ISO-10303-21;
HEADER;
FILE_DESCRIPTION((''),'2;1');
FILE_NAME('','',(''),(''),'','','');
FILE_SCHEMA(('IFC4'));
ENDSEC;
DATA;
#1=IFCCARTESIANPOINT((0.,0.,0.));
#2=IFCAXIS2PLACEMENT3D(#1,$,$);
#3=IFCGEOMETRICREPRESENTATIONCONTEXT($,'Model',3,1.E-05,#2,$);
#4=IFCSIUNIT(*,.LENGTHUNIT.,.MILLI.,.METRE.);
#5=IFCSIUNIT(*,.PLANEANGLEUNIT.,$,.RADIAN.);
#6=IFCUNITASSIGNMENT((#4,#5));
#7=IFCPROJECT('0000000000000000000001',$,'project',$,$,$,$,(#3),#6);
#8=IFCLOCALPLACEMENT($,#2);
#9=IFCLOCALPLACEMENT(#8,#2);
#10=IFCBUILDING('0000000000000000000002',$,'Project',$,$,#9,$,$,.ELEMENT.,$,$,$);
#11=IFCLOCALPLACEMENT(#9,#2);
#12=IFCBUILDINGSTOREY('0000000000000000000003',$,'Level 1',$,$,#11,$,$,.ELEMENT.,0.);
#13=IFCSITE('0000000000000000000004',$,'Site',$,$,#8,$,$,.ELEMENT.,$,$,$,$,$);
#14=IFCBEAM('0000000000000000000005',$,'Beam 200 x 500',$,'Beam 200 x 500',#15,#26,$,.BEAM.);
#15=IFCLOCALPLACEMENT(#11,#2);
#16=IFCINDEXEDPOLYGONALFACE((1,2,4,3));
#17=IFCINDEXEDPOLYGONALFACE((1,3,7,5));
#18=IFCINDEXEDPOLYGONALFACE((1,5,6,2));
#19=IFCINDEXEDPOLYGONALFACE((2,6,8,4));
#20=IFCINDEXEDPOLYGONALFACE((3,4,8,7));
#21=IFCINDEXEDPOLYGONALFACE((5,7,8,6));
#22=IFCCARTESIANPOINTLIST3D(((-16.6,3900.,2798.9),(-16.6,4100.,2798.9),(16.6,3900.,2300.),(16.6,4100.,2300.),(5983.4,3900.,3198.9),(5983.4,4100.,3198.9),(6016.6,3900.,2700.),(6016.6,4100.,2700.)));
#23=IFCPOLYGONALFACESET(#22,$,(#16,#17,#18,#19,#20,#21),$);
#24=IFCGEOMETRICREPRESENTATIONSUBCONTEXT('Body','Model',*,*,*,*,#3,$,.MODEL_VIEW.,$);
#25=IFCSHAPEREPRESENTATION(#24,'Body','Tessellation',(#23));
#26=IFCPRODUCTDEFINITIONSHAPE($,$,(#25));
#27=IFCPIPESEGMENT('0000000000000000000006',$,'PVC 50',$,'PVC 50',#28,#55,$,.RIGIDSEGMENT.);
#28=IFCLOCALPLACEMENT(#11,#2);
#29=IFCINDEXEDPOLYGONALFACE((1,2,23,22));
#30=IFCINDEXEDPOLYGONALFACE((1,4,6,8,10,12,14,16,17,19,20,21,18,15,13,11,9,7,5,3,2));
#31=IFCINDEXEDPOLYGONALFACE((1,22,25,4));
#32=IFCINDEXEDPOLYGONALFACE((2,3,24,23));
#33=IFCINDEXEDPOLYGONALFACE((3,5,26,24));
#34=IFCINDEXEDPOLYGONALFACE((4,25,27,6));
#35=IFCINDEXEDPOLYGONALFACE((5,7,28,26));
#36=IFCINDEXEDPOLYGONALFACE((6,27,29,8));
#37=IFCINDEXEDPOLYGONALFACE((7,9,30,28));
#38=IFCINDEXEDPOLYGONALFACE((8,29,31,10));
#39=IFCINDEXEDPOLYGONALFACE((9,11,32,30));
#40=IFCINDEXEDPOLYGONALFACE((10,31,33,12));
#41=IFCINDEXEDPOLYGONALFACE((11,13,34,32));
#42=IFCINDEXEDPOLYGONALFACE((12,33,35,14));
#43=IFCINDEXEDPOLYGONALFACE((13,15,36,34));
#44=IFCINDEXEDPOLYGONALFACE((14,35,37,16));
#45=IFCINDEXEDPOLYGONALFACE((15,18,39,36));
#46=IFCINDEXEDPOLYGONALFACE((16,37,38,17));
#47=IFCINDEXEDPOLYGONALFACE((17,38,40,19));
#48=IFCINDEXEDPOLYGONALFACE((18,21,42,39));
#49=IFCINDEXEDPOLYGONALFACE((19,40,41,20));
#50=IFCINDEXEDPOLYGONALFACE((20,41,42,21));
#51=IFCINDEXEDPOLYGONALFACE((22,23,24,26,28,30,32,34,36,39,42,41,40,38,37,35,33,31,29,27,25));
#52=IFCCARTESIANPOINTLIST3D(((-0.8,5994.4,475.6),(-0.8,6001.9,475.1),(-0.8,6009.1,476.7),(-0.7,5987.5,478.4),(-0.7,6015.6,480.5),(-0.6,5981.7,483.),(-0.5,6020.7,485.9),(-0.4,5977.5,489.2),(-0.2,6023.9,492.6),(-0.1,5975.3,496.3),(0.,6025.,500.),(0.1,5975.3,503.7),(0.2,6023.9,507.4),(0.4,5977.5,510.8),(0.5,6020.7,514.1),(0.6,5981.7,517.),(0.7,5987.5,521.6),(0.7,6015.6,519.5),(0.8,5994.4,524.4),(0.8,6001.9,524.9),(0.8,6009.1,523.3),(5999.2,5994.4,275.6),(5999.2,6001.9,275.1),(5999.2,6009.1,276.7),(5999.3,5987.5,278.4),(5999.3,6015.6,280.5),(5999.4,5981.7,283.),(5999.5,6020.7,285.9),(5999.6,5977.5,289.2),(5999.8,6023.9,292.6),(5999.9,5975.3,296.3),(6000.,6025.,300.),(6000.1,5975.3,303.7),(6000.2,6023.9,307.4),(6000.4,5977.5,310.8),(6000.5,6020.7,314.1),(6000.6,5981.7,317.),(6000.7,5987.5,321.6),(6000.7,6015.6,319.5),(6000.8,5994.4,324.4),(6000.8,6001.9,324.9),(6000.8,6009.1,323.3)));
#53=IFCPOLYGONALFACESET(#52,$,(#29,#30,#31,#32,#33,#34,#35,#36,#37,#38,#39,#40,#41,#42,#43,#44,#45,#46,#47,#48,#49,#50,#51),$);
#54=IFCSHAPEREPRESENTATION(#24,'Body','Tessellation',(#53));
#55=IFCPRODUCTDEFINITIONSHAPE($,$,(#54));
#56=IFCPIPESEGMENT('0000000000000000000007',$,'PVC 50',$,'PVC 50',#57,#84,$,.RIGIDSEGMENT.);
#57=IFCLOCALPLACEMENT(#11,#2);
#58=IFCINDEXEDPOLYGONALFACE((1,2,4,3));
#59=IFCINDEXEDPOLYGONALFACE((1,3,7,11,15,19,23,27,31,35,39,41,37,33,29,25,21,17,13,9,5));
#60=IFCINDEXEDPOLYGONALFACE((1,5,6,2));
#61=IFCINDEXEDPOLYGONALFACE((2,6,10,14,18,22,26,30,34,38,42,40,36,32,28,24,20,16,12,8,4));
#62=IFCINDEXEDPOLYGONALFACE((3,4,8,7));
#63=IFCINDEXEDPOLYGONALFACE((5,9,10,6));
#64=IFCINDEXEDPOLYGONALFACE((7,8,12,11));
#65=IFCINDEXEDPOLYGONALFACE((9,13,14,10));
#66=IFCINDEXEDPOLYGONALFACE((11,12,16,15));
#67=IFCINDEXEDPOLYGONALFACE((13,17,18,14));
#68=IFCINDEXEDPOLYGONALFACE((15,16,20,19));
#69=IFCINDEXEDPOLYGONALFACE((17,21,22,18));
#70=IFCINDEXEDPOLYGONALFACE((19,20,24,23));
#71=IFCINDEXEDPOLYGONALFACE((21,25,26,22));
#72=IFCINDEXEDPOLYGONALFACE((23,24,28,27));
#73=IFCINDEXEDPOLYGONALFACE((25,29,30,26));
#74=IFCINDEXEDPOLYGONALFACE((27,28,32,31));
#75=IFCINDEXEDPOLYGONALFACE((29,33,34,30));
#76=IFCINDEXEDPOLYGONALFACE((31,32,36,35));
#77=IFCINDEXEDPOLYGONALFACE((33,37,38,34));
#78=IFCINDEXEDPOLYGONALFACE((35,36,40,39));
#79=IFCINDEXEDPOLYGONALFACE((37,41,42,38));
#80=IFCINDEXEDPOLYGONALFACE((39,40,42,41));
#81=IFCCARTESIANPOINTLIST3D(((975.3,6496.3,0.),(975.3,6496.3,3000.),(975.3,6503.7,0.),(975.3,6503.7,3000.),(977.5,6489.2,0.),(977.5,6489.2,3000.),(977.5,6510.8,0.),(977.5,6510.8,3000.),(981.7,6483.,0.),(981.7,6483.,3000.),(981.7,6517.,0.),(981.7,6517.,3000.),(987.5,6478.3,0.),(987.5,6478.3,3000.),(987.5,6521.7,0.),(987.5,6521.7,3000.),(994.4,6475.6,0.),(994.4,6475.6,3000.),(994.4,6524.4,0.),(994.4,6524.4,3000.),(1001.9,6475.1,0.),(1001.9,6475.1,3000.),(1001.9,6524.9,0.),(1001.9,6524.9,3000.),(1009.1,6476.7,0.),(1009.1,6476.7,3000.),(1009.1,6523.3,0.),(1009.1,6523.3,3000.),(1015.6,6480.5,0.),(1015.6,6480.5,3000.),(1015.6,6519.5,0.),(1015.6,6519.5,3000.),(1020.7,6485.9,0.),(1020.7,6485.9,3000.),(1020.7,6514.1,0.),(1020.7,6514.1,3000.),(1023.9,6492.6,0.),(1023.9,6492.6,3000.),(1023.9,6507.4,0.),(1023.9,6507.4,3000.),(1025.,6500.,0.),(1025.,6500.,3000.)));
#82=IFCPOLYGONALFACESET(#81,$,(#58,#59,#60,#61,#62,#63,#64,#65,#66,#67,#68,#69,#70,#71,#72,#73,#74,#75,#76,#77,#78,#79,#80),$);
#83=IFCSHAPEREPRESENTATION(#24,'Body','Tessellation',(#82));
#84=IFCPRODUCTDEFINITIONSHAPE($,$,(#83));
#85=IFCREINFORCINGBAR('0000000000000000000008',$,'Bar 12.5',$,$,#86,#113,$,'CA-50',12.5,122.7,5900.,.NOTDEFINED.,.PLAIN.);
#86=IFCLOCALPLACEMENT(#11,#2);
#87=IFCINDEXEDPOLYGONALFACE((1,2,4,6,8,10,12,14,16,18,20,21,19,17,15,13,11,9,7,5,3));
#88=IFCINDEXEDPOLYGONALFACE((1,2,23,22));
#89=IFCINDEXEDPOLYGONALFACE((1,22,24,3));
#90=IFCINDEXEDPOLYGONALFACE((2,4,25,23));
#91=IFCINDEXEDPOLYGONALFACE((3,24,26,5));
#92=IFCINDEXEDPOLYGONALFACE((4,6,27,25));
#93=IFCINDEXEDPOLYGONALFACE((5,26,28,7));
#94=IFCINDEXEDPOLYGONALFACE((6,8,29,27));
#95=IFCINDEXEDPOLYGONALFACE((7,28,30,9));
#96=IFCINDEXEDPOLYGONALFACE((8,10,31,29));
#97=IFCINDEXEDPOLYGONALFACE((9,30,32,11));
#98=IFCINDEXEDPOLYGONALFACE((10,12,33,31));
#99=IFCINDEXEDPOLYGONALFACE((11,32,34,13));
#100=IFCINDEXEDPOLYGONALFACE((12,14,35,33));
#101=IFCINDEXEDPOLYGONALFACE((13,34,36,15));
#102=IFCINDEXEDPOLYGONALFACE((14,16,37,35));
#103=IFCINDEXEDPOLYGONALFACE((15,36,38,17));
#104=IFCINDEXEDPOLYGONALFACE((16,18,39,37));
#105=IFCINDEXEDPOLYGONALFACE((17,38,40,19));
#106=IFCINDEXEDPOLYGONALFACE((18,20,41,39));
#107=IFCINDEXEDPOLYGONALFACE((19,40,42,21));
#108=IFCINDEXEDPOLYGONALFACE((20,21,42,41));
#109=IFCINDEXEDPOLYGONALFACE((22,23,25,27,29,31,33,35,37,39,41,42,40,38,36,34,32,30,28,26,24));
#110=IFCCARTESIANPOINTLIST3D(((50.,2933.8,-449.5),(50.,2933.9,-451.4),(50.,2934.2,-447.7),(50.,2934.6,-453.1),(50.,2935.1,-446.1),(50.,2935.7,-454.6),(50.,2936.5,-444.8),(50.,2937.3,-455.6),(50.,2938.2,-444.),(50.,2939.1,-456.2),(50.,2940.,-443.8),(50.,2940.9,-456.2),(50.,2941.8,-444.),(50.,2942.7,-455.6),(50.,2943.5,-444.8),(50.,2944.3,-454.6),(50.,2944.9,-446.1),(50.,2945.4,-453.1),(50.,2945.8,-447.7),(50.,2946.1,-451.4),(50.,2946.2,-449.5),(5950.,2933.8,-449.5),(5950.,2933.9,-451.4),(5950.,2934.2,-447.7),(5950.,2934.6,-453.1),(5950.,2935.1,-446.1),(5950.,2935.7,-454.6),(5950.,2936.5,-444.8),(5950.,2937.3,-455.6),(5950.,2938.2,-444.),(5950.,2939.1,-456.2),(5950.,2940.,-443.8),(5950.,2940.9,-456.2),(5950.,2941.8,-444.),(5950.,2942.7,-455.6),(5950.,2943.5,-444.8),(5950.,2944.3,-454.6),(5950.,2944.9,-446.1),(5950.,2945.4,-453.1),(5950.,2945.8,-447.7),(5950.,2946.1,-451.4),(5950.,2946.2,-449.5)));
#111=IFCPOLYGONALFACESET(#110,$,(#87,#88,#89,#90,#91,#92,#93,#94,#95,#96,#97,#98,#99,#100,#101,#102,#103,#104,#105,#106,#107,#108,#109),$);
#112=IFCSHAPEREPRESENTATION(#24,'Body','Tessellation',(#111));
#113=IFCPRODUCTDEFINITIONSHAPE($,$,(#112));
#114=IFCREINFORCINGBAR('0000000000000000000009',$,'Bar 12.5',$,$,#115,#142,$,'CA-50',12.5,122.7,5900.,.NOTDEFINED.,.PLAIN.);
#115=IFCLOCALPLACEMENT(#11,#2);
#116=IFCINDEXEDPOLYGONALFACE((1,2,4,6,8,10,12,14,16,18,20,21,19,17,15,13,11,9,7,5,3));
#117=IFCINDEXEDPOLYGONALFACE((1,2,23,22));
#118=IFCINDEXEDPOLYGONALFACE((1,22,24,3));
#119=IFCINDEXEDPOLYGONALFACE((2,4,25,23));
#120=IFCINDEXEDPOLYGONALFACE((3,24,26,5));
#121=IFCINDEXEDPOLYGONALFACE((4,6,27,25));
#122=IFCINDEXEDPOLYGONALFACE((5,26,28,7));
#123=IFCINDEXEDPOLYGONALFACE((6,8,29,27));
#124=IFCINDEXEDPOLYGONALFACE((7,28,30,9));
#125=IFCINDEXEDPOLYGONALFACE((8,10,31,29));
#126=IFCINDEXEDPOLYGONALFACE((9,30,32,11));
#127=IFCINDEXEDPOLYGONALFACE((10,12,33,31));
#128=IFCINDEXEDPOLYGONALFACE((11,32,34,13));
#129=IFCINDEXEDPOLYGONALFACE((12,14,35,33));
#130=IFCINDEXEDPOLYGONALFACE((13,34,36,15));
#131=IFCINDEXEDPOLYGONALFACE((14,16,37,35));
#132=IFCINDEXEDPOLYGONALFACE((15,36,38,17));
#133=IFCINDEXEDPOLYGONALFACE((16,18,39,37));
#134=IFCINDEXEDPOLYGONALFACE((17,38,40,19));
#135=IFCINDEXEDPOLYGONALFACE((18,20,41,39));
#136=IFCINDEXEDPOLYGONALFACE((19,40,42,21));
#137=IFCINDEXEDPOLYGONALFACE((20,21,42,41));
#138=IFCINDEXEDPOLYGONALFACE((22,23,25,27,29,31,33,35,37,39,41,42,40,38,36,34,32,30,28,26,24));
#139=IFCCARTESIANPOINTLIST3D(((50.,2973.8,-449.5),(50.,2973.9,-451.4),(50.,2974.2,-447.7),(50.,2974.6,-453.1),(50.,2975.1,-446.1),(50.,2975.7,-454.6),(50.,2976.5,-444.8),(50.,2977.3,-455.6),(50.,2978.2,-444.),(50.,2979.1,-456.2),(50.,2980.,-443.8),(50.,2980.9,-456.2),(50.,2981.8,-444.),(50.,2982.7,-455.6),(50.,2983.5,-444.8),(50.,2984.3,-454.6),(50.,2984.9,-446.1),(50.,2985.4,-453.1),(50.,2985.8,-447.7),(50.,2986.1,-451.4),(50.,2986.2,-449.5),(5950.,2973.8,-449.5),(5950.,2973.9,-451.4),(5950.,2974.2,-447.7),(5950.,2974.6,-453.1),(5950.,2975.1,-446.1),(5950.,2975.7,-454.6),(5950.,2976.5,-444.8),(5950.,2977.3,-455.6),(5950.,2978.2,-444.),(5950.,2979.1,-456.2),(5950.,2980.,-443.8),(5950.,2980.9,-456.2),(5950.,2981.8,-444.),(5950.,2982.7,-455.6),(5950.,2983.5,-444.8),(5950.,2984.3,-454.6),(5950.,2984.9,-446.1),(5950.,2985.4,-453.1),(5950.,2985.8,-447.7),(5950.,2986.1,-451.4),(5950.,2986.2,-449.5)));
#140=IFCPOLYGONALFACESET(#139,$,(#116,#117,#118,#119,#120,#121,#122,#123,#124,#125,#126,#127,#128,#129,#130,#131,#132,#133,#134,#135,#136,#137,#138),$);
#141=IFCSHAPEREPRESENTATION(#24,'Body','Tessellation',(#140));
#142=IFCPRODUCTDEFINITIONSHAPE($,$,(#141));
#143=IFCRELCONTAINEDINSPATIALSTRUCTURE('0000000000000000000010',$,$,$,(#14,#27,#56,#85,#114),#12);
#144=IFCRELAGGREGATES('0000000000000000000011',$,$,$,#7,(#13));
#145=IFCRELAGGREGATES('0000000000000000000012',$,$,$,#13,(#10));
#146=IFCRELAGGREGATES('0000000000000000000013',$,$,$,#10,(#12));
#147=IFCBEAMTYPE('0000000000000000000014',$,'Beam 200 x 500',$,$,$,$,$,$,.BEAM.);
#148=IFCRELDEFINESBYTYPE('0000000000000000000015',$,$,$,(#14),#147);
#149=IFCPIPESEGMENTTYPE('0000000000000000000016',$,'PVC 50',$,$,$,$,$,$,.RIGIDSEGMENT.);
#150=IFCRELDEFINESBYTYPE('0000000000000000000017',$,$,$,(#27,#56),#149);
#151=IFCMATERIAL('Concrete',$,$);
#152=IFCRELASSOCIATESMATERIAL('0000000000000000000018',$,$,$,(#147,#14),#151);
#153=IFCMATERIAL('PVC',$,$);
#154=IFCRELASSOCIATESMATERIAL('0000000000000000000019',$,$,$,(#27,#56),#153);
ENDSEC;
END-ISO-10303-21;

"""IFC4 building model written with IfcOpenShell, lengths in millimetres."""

from ifc_helpers import new_model, entity, si_unit, frame, origin, origin_with_axes, origin_2d, place, context, subcontext, project, spatial, rectangle, circle, extrude, material, material_profile, profile_set, profile_usage, type_object, element, save


model = new_model("IFC4")

# Units and contexts
model_context = context("Model", 3, precision=1e-05, world=origin())
body_context = subcontext(model_context, "Body", "Model", "MODEL_VIEW")
ifc_project = project(units=[si_unit("LENGTHUNIT", "METRE", prefix="MILLI"), si_unit("PLANEANGLEUNIT", "RADIAN")], contexts=[model_context])

# Site, building, storey
site_placement = place(None, origin())
site = spatial("IfcSite", under=ifc_project, at=site_placement, Name="Site", CompositionType="ELEMENT")
building_placement = place(site_placement, origin())
building = spatial("IfcBuilding", under=site, at=building_placement, Name="Project", CompositionType="ELEMENT")
storey_placement = place(building_placement, origin())
storey = spatial("IfcBuildingStorey", under=building, at=storey_placement, Name="Level 1", CompositionType="ELEMENT", Elevation=0.0)

# Beam
ifc_material_1 = material(Name="Concrete")
ifc_material_profile = material_profile(ifc_material_1, rectangle(XDim=200.0, YDim=500.0, at=origin_2d()), Name="Beam 200 x 500")
ifc_profile_set = profile_set([ifc_material_profile], Name="Beam 200 x 500")
ifc_profile_usage = profile_usage(ifc_profile_set, cardinal=8)
beam_type = type_object("IfcBeamType", Name="Beam 200 x 500", PredefinedType="BEAM", material=ifc_profile_set)
beam_placement = place(storey_placement, frame((0.0, 4000.0, 2549.4)))
element("IfcBeam", 1, at=beam_placement, inside=storey, type_object=beam_type, material=ifc_profile_usage, Name="Beam 200 x 500", ObjectType="Beam 200 x 500", PredefinedType="BEAM", context=body_context, shape_type="SweptSolid", body=[
    extrude(rectangle(XDim=200.0, YDim=500.0, at=origin_2d()), frame((0.0, 0.0, 0.0), z_axis=(0.997785, 0.0, 0.066519), x_axis=(0.0, 1.0, 0.0)), (0.0, 0.0, 1.0), 6013.3),
])

# Pipe segments
ifc_material_2 = material(Name="PVC")
pipe_segment_type = type_object("IfcPipeSegmentType", Name="PVC 50", PredefinedType="RIGIDSEGMENT")
pipe_segment_1_placement = place(storey_placement, frame((0.0, 6000.0, 500.0)))
element("IfcPipeSegment", 2, at=pipe_segment_1_placement, inside=storey, type_object=pipe_segment_type, material=ifc_material_2, Name="PVC 50", ObjectType="PVC 50", PredefinedType="RIGIDSEGMENT", context=body_context, shape_type="SweptSolid", body=[
    extrude(circle(Radius=25.0, at=origin_2d()), frame((0.0, 0.0, 0.0), z_axis=(0.999445, 0.0, -0.033315), x_axis=(0.0, 1.0, 0.0)), (0.0, 0.0, 1.0), 6003.3),
])
pipe_segment_2_placement = place(storey_placement, frame((1000.0, 6500.0, 0.0)))
element("IfcPipeSegment", 3, at=pipe_segment_2_placement, inside=storey, type_object=pipe_segment_type, material=ifc_material_2, Name="PVC 50", ObjectType="PVC 50", PredefinedType="RIGIDSEGMENT", context=body_context, shape_type="SweptSolid", body=[
    extrude(circle(Radius=25.0, at=origin_2d()), origin_with_axes(), (0.0, 0.0, 1.0), 3000.0),
])

# Reinforcing bars
reinforcing_bar_1_placement = place(storey_placement, origin())
element("IfcReinforcingBar", 4, at=reinforcing_bar_1_placement, inside=storey, Name="Bar 12.5", SteelGrade="CA-50", BarLength=5900.0, BarSurface="PLAIN", CrossSectionArea=122.7, NominalDiameter=12.5, PredefinedType="NOTDEFINED", context=body_context, shape_type="AdvancedSweptSolid", body=[
    entity("IfcSweptDiskSolid", entity("IfcPolyline", [entity("IfcCartesianPoint", [50.0, 2940.0, -450.0]), entity("IfcCartesianPoint", [5950.0, 2940.0, -450.0])]), 6.2),
])
reinforcing_bar_2_placement = place(storey_placement, origin())
element("IfcReinforcingBar", 5, at=reinforcing_bar_2_placement, inside=storey, Name="Bar 12.5", SteelGrade="CA-50", BarLength=5900.0, BarSurface="PLAIN", CrossSectionArea=122.7, NominalDiameter=12.5, PredefinedType="NOTDEFINED", context=body_context, shape_type="AdvancedSweptSolid", body=[
    entity("IfcSweptDiskSolid", entity("IfcPolyline", [entity("IfcCartesianPoint", [50.0, 2980.0, -450.0]), entity("IfcCartesianPoint", [5950.0, 2980.0, -450.0])]), 6.2),
])

save(model, "model.ifc")
